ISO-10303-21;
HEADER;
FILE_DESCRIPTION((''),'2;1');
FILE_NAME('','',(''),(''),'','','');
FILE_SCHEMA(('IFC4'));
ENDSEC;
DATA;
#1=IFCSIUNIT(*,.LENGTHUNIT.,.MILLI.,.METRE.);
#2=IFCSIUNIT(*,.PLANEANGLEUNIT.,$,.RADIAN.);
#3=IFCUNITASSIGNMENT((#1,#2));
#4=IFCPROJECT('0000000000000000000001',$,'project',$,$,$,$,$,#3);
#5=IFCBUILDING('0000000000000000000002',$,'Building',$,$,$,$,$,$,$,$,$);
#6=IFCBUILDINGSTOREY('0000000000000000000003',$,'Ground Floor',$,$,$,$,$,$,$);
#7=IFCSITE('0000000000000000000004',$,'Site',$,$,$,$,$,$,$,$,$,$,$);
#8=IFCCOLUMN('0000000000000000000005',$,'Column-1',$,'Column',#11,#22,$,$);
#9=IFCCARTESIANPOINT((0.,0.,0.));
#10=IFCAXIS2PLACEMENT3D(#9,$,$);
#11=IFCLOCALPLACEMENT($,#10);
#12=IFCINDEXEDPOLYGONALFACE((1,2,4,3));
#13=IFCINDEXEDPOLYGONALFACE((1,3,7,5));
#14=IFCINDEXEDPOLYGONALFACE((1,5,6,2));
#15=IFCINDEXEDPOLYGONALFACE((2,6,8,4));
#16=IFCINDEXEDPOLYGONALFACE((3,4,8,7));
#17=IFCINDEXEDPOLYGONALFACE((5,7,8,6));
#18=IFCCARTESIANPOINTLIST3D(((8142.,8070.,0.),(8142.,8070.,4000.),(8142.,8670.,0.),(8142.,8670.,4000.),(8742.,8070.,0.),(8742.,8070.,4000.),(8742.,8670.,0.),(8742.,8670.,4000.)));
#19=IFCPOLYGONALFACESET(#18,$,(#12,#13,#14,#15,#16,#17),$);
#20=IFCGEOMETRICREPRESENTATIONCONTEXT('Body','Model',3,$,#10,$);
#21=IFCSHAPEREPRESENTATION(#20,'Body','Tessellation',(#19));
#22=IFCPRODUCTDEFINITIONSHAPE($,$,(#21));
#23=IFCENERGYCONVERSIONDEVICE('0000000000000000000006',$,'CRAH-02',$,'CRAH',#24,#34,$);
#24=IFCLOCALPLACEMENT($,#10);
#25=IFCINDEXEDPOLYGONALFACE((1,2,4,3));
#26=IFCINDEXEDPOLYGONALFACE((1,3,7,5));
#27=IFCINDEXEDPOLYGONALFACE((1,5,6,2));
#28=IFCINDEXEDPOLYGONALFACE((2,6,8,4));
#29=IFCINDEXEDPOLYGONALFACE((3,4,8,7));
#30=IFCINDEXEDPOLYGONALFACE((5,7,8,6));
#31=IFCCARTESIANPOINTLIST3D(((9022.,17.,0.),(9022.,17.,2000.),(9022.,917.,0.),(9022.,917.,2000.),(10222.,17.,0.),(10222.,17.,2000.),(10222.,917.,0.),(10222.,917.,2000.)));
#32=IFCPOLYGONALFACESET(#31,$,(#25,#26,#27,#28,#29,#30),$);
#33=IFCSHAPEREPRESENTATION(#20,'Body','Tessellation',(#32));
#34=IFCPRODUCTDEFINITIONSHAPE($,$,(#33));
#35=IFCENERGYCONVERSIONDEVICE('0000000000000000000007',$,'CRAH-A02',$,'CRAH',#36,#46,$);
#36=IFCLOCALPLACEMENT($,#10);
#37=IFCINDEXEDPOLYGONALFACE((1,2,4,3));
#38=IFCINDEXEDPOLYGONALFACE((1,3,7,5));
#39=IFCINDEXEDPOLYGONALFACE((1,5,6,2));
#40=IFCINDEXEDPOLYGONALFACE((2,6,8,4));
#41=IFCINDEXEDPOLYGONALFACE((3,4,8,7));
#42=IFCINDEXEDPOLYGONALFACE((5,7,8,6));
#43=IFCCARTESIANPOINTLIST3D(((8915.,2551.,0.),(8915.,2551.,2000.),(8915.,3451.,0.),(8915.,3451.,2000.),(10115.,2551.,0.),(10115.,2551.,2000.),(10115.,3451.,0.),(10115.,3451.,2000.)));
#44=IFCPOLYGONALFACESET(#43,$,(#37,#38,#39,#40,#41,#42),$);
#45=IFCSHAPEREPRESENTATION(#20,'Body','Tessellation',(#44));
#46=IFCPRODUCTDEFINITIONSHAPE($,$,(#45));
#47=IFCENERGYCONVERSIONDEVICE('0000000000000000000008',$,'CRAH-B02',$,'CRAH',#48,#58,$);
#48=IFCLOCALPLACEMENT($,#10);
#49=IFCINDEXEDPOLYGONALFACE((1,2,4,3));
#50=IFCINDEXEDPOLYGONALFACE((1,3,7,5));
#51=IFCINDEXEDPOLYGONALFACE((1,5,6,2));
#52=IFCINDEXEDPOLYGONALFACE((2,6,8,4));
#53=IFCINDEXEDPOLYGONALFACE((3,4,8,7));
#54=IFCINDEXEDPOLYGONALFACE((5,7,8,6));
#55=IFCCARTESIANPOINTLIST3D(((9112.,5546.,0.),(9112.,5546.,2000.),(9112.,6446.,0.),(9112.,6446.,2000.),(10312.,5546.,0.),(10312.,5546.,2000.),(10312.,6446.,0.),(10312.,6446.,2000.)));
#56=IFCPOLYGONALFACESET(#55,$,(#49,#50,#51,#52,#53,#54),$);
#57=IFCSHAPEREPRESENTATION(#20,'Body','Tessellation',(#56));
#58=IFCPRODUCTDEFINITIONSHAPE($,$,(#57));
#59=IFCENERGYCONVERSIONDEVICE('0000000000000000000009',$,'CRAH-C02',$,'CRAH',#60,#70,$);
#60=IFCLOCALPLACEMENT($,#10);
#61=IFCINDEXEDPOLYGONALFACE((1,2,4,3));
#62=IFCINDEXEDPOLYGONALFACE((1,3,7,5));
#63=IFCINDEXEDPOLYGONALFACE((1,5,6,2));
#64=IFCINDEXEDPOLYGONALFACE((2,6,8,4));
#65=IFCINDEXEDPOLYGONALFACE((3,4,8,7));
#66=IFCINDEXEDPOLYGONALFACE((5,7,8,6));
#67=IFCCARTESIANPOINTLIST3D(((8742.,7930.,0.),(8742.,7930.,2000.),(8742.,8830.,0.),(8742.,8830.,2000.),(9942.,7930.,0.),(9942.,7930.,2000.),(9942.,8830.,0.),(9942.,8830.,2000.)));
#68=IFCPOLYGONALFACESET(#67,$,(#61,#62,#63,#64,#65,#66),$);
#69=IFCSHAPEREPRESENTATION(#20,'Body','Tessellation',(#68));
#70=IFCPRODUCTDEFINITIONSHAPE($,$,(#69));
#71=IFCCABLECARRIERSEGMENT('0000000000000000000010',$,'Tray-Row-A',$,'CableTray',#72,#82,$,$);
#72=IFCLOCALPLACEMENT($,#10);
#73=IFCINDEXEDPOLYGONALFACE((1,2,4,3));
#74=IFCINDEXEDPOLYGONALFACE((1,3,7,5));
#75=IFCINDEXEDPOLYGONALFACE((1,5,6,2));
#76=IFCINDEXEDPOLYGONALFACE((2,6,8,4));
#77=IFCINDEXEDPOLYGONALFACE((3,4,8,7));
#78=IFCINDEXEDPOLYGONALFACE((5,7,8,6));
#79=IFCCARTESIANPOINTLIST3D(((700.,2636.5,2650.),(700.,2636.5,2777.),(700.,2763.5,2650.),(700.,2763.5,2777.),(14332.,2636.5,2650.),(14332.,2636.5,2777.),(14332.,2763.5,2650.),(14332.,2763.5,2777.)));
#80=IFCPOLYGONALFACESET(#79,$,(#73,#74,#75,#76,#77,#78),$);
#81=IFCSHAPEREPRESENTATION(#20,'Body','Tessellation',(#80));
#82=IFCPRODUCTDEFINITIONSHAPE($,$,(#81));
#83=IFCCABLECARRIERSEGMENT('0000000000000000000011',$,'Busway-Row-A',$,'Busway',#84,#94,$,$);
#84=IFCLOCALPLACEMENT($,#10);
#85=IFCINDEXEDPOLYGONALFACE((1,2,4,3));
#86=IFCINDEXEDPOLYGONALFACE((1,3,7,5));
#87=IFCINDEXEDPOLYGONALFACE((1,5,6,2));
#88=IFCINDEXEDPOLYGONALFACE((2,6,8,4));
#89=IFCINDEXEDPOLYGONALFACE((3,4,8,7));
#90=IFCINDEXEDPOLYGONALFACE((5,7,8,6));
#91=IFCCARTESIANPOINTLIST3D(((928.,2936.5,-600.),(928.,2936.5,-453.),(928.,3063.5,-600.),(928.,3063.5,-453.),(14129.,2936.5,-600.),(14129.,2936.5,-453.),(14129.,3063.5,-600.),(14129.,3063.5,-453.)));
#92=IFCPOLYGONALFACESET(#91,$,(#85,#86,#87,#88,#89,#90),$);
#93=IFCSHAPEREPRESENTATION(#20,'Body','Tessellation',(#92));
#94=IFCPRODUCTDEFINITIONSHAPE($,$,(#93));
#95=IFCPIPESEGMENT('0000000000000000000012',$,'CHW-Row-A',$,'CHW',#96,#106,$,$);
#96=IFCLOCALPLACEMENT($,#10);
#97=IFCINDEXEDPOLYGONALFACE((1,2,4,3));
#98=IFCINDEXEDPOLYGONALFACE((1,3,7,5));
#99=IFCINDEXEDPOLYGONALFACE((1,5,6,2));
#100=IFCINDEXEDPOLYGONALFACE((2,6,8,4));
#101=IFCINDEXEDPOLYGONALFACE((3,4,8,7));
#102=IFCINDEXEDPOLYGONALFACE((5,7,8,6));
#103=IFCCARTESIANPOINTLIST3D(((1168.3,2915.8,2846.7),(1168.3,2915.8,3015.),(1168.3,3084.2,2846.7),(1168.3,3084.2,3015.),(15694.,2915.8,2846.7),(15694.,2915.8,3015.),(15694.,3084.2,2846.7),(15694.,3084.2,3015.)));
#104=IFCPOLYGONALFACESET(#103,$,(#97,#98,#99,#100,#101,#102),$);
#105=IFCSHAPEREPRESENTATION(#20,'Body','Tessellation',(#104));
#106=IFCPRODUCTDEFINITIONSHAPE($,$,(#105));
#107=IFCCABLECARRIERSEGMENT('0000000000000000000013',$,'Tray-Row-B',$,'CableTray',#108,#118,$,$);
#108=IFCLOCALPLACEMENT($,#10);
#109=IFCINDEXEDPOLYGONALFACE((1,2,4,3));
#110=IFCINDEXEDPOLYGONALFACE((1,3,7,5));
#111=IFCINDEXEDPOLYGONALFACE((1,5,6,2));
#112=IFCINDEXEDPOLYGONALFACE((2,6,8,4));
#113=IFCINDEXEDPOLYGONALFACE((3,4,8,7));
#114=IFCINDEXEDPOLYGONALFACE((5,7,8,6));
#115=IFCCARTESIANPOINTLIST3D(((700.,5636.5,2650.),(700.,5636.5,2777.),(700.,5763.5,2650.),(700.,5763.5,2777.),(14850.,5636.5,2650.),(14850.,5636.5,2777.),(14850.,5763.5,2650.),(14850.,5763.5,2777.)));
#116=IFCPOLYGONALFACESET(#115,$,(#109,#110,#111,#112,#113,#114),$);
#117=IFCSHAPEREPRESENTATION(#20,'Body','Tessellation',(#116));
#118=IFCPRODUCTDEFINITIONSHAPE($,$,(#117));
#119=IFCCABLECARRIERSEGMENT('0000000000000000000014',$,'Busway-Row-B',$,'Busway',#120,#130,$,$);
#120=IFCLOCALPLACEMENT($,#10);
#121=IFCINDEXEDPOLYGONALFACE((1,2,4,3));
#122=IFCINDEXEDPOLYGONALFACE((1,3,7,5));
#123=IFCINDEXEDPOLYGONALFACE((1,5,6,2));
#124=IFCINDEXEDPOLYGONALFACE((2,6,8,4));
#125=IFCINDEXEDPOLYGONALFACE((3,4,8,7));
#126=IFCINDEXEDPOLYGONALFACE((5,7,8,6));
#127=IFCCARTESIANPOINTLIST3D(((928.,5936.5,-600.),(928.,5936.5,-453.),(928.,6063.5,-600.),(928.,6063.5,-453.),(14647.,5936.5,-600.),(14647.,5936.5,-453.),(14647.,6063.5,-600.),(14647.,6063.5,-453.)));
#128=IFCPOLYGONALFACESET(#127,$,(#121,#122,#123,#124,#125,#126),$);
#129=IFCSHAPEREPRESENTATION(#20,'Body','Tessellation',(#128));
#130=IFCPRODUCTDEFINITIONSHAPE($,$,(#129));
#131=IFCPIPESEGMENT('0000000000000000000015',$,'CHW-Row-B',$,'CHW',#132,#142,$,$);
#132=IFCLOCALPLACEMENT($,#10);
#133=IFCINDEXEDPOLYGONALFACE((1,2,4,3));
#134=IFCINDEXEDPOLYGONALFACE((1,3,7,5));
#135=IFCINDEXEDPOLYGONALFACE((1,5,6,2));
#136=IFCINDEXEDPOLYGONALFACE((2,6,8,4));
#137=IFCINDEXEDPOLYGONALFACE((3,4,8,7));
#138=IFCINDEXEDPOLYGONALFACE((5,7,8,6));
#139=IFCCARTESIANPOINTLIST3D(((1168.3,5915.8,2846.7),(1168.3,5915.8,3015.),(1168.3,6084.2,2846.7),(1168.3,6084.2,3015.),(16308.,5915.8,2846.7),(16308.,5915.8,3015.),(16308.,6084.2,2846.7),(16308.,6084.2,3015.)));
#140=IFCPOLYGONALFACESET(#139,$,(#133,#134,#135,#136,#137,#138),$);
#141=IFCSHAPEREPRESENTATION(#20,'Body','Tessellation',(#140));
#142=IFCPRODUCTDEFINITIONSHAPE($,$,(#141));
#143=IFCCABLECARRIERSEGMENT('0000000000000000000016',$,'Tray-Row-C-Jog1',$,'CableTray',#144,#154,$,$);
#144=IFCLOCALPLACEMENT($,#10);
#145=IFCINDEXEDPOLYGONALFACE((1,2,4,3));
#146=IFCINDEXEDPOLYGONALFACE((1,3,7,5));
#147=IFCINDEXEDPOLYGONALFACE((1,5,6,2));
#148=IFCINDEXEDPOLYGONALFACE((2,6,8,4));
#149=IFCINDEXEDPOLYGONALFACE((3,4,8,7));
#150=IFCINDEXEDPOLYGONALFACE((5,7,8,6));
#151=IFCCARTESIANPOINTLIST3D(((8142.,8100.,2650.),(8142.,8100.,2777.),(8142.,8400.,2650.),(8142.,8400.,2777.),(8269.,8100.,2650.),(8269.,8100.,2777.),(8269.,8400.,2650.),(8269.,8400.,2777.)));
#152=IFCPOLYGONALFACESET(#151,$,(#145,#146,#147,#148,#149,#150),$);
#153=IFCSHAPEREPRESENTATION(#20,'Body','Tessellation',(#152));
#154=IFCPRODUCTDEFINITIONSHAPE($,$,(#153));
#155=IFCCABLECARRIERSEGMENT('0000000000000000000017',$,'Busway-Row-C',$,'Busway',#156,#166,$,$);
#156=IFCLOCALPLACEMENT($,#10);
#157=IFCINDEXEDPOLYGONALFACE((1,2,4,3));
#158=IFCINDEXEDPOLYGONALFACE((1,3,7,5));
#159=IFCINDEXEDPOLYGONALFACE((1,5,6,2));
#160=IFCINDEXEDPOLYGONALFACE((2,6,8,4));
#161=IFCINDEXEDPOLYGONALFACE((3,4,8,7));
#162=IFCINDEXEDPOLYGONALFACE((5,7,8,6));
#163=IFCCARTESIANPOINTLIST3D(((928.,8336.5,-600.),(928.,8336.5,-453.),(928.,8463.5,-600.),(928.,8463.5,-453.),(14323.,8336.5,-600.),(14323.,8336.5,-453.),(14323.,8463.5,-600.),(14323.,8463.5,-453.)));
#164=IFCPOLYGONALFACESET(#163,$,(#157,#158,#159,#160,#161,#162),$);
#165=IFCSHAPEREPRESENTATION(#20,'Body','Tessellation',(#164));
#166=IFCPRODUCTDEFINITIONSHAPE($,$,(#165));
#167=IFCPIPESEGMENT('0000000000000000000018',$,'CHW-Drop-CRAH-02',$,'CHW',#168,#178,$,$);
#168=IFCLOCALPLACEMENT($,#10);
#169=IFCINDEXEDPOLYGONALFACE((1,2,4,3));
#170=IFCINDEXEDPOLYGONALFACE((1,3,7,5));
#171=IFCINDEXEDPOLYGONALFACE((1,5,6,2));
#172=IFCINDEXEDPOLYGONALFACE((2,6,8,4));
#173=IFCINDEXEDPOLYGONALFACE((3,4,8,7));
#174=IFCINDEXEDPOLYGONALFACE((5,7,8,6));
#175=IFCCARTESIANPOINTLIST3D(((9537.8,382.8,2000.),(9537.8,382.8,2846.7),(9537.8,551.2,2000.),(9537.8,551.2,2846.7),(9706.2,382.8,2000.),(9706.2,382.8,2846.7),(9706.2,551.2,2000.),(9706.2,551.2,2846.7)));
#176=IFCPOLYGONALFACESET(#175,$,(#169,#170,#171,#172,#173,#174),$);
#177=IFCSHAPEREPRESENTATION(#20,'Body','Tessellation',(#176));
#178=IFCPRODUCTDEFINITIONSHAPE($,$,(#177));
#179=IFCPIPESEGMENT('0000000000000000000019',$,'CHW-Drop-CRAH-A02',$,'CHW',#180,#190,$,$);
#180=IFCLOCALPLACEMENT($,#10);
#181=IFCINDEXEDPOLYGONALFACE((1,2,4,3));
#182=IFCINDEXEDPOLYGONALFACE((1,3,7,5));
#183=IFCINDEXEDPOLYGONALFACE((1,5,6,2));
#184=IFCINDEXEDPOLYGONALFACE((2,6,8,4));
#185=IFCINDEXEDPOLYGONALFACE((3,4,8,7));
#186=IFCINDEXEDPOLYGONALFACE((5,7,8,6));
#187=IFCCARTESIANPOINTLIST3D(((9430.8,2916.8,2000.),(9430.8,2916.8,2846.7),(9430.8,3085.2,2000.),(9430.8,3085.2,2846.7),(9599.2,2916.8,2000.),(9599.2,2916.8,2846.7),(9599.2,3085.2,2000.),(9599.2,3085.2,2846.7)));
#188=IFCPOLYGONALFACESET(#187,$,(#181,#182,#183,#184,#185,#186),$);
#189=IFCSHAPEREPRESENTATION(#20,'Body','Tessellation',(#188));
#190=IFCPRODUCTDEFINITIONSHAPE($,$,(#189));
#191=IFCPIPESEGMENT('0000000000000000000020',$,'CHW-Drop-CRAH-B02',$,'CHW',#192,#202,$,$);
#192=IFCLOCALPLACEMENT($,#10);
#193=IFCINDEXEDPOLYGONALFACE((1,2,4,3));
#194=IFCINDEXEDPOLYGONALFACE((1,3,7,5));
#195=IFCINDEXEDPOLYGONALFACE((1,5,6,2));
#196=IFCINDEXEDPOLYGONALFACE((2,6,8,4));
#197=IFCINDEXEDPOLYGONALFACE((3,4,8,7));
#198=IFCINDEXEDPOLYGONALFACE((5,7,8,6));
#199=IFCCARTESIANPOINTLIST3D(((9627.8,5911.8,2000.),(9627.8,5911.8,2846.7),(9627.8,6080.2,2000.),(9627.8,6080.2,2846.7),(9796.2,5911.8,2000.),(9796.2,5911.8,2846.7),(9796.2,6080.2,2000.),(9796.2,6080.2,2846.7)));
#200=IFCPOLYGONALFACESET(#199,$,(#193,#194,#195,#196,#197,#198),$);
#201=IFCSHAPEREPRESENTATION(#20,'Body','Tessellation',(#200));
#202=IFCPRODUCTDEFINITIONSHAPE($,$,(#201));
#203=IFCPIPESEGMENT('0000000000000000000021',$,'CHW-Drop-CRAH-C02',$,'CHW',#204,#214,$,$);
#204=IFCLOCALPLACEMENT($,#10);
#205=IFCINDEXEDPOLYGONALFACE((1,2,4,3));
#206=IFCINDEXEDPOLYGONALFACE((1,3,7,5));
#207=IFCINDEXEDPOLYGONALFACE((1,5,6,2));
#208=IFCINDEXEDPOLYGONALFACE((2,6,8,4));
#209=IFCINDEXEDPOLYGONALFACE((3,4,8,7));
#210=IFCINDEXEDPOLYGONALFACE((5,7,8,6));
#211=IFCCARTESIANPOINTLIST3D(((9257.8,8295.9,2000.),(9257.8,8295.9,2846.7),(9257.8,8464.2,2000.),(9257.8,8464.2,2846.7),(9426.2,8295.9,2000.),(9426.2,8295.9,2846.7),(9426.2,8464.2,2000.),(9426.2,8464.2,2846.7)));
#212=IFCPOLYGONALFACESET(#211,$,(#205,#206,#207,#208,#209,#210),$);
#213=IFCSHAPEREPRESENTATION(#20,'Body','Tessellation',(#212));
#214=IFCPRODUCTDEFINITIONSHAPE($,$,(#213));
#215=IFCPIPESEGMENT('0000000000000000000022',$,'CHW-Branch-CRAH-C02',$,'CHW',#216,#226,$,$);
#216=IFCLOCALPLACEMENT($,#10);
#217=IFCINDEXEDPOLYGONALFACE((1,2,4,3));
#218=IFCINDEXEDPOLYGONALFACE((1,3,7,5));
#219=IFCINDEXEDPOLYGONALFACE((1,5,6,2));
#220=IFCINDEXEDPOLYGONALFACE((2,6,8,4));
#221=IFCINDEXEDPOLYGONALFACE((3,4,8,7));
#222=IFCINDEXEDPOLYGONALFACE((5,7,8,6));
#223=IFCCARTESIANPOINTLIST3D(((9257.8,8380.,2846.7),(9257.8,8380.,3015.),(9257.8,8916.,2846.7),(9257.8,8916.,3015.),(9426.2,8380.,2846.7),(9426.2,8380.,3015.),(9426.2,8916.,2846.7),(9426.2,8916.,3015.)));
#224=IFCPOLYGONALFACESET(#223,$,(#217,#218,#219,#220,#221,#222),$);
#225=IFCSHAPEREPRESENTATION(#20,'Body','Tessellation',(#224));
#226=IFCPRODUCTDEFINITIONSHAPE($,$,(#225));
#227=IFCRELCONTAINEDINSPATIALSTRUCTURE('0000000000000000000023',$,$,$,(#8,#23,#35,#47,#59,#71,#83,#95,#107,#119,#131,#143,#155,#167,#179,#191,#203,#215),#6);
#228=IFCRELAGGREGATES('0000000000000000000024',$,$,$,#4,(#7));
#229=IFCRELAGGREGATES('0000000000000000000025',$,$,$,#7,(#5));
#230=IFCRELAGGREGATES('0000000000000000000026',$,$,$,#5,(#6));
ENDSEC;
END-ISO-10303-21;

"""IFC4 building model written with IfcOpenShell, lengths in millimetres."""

from ifc_helpers import new_model, si_unit, frame, origin, place, context, project, spatial, rectangle, extrude, element, save


model = new_model("IFC4")

# Units and contexts
model_context = context("Model", 3, world=origin(), identifier="Body")
ifc_project = project(units=[si_unit("LENGTHUNIT", "METRE", prefix="MILLI"), si_unit("PLANEANGLEUNIT", "RADIAN")])

# Site, building, storey
site = spatial("IfcSite", under=ifc_project, Name="Site")
building = spatial("IfcBuilding", under=site, Name="Building")
storey = spatial("IfcBuildingStorey", under=building, Name="Ground Floor")

# Column
column_placement = place(None, frame((8442.0, 8370.0, 0.0), z_axis=(0.0, 0.0, 1.0), x_axis=(1.0, 0.0, 0.0)))
element("IfcColumn", 1, at=column_placement, inside=storey, Name="Column-1", ObjectType="Column", context=model_context, shape_type="SweptSolid", body=[
    extrude(rectangle(XDim=600.0, YDim=600.0), origin(), (0.0, 0.0, 1.0), 4000.0),
])

# Energy conversion devices
for number, where, z_axis, x_axis, name in (
    (2, (9622.0, 467.0, 0.0), (0.0, 0.0, 1.0), (1.0, 0.0, 0.0), "CRAH-02"),
    (3, (9515.0, 3001.0, 0.0), (0.0, 0.0, 1.0), (1.0, 0.0, 0.0), "CRAH-A02"),
    (4, (9712.0, 5996.0, 0.0), (0.0, 0.0, 1.0), (1.0, 0.0, 0.0), "CRAH-B02"),
    (5, (9342.0, 8380.0, 0.0), (0.0, 0.0, 1.0), (1.0, 0.0, 0.0), "CRAH-C02"),
):
    element("IfcEnergyConversionDevice", number, at=place(None, frame(where, z_axis=z_axis, x_axis=x_axis)), inside=storey, Name=name, ObjectType="CRAH", context=model_context, shape_type="SweptSolid", body=[
        extrude(rectangle(XDim=1200.0, YDim=900.0), origin(), (0.0, 0.0, 1.0), 2000.0),
    ])

# Cable carrier segments
cable_carrier_segment_1_placement = place(None, frame((7516.0, 2700.0, 2650.0), z_axis=(0.0, 0.0, 1.0), x_axis=(1.0, 0.0, 0.0)))
element("IfcCableCarrierSegment", 6, at=cable_carrier_segment_1_placement, inside=storey, Name="Tray-Row-A", ObjectType="CableTray", context=model_context, shape_type="SweptSolid", body=[
    extrude(rectangle(XDim=13632.0, YDim=127.0), origin(), (0.0, 0.0, 1.0), 127.0),
])
cable_carrier_segment_2_placement = place(None, frame((7528.5, 3000.0, -600.0), z_axis=(0.0, 0.0, 1.0), x_axis=(1.0, 0.0, 0.0)))
element("IfcCableCarrierSegment", 7, at=cable_carrier_segment_2_placement, inside=storey, Name="Busway-Row-A", ObjectType="Busway", context=model_context, shape_type="SweptSolid", body=[
    extrude(rectangle(XDim=13201.0, YDim=127.0), origin(), (0.0, 0.0, 1.0), 147.0),
])

# Pipe segment
pipe_segment_1_placement = place(None, frame((8431.1, 3000.0, 2846.7), z_axis=(0.0, 0.0, 1.0), x_axis=(1.0, 0.0, 0.0)))
element("IfcPipeSegment", 8, at=pipe_segment_1_placement, inside=storey, Name="CHW-Row-A", ObjectType="CHW", context=model_context, shape_type="SweptSolid", body=[
    extrude(rectangle(XDim=14525.7, YDim=168.3), origin(), (0.0, 0.0, 1.0), 168.3),
])

# Cable carrier segments
cable_carrier_segment_3_placement = place(None, frame((7775.0, 5700.0, 2650.0), z_axis=(0.0, 0.0, 1.0), x_axis=(1.0, 0.0, 0.0)))
element("IfcCableCarrierSegment", 9, at=cable_carrier_segment_3_placement, inside=storey, Name="Tray-Row-B", ObjectType="CableTray", context=model_context, shape_type="SweptSolid", body=[
    extrude(rectangle(XDim=14150.0, YDim=127.0), origin(), (0.0, 0.0, 1.0), 127.0),
])
cable_carrier_segment_4_placement = place(None, frame((7787.5, 6000.0, -600.0), z_axis=(0.0, 0.0, 1.0), x_axis=(1.0, 0.0, 0.0)))
element("IfcCableCarrierSegment", 10, at=cable_carrier_segment_4_placement, inside=storey, Name="Busway-Row-B", ObjectType="Busway", context=model_context, shape_type="SweptSolid", body=[
    extrude(rectangle(XDim=13719.0, YDim=127.0), origin(), (0.0, 0.0, 1.0), 147.0),
])

# Pipe segment
pipe_segment_2_placement = place(None, frame((8738.1, 6000.0, 2846.7), z_axis=(0.0, 0.0, 1.0), x_axis=(1.0, 0.0, 0.0)))
element("IfcPipeSegment", 11, at=pipe_segment_2_placement, inside=storey, Name="CHW-Row-B", ObjectType="CHW", context=model_context, shape_type="SweptSolid", body=[
    extrude(rectangle(XDim=15139.7, YDim=168.3), origin(), (0.0, 0.0, 1.0), 168.3),
])

# Cable carrier segments
cable_carrier_segment_5_placement = place(None, frame((8205.5, 8250.0, 2650.0), z_axis=(0.0, 0.0, 1.0), x_axis=(1.0, 0.0, 0.0)))
element("IfcCableCarrierSegment", 12, at=cable_carrier_segment_5_placement, inside=storey, Name="Tray-Row-C-Jog1", ObjectType="CableTray", context=model_context, shape_type="SweptSolid", body=[
    extrude(rectangle(XDim=127.0, YDim=300.0), origin(), (0.0, 0.0, 1.0), 127.0),
])
cable_carrier_segment_6_placement = place(None, frame((7625.5, 8400.0, -600.0), z_axis=(0.0, 0.0, 1.0), x_axis=(1.0, 0.0, 0.0)))
element("IfcCableCarrierSegment", 13, at=cable_carrier_segment_6_placement, inside=storey, Name="Busway-Row-C", ObjectType="Busway", context=model_context, shape_type="SweptSolid", body=[
    extrude(rectangle(XDim=13395.0, YDim=127.0), origin(), (0.0, 0.0, 1.0), 147.0),
])

# Pipe segments
for number, where, z_axis, x_axis, name in (
    (14, (9622.0, 467.0, 2000.0), (0.0, 0.0, 1.0), (1.0, 0.0, 0.0), "CHW-Drop-CRAH-02"),
    (15, (9515.0, 3001.0, 2000.0), (0.0, 0.0, 1.0), (1.0, 0.0, 0.0), "CHW-Drop-CRAH-A02"),
    (16, (9712.0, 5996.0, 2000.0), (0.0, 0.0, 1.0), (1.0, 0.0, 0.0), "CHW-Drop-CRAH-B02"),
    (17, (9342.0, 8380.0, 2000.0), (0.0, 0.0, 1.0), (1.0, 0.0, 0.0), "CHW-Drop-CRAH-C02"),
):
    element("IfcPipeSegment", number, at=place(None, frame(where, z_axis=z_axis, x_axis=x_axis)), inside=storey, Name=name, ObjectType="CHW", context=model_context, shape_type="SweptSolid", body=[
        extrude(rectangle(XDim=168.3, YDim=168.3), origin(), (0.0, 0.0, 1.0), 846.7),
    ])
pipe_segment_3_placement = place(None, frame((9342.0, 8648.0, 2846.7), z_axis=(0.0, 0.0, 1.0), x_axis=(1.0, 0.0, 0.0)))
element("IfcPipeSegment", 18, at=pipe_segment_3_placement, inside=storey, Name="CHW-Branch-CRAH-C02", ObjectType="CHW", context=model_context, shape_type="SweptSolid", body=[
    extrude(rectangle(XDim=168.3, YDim=536.0), origin(), (0.0, 0.0, 1.0), 168.3),
])

save(model, "model.ifc")
